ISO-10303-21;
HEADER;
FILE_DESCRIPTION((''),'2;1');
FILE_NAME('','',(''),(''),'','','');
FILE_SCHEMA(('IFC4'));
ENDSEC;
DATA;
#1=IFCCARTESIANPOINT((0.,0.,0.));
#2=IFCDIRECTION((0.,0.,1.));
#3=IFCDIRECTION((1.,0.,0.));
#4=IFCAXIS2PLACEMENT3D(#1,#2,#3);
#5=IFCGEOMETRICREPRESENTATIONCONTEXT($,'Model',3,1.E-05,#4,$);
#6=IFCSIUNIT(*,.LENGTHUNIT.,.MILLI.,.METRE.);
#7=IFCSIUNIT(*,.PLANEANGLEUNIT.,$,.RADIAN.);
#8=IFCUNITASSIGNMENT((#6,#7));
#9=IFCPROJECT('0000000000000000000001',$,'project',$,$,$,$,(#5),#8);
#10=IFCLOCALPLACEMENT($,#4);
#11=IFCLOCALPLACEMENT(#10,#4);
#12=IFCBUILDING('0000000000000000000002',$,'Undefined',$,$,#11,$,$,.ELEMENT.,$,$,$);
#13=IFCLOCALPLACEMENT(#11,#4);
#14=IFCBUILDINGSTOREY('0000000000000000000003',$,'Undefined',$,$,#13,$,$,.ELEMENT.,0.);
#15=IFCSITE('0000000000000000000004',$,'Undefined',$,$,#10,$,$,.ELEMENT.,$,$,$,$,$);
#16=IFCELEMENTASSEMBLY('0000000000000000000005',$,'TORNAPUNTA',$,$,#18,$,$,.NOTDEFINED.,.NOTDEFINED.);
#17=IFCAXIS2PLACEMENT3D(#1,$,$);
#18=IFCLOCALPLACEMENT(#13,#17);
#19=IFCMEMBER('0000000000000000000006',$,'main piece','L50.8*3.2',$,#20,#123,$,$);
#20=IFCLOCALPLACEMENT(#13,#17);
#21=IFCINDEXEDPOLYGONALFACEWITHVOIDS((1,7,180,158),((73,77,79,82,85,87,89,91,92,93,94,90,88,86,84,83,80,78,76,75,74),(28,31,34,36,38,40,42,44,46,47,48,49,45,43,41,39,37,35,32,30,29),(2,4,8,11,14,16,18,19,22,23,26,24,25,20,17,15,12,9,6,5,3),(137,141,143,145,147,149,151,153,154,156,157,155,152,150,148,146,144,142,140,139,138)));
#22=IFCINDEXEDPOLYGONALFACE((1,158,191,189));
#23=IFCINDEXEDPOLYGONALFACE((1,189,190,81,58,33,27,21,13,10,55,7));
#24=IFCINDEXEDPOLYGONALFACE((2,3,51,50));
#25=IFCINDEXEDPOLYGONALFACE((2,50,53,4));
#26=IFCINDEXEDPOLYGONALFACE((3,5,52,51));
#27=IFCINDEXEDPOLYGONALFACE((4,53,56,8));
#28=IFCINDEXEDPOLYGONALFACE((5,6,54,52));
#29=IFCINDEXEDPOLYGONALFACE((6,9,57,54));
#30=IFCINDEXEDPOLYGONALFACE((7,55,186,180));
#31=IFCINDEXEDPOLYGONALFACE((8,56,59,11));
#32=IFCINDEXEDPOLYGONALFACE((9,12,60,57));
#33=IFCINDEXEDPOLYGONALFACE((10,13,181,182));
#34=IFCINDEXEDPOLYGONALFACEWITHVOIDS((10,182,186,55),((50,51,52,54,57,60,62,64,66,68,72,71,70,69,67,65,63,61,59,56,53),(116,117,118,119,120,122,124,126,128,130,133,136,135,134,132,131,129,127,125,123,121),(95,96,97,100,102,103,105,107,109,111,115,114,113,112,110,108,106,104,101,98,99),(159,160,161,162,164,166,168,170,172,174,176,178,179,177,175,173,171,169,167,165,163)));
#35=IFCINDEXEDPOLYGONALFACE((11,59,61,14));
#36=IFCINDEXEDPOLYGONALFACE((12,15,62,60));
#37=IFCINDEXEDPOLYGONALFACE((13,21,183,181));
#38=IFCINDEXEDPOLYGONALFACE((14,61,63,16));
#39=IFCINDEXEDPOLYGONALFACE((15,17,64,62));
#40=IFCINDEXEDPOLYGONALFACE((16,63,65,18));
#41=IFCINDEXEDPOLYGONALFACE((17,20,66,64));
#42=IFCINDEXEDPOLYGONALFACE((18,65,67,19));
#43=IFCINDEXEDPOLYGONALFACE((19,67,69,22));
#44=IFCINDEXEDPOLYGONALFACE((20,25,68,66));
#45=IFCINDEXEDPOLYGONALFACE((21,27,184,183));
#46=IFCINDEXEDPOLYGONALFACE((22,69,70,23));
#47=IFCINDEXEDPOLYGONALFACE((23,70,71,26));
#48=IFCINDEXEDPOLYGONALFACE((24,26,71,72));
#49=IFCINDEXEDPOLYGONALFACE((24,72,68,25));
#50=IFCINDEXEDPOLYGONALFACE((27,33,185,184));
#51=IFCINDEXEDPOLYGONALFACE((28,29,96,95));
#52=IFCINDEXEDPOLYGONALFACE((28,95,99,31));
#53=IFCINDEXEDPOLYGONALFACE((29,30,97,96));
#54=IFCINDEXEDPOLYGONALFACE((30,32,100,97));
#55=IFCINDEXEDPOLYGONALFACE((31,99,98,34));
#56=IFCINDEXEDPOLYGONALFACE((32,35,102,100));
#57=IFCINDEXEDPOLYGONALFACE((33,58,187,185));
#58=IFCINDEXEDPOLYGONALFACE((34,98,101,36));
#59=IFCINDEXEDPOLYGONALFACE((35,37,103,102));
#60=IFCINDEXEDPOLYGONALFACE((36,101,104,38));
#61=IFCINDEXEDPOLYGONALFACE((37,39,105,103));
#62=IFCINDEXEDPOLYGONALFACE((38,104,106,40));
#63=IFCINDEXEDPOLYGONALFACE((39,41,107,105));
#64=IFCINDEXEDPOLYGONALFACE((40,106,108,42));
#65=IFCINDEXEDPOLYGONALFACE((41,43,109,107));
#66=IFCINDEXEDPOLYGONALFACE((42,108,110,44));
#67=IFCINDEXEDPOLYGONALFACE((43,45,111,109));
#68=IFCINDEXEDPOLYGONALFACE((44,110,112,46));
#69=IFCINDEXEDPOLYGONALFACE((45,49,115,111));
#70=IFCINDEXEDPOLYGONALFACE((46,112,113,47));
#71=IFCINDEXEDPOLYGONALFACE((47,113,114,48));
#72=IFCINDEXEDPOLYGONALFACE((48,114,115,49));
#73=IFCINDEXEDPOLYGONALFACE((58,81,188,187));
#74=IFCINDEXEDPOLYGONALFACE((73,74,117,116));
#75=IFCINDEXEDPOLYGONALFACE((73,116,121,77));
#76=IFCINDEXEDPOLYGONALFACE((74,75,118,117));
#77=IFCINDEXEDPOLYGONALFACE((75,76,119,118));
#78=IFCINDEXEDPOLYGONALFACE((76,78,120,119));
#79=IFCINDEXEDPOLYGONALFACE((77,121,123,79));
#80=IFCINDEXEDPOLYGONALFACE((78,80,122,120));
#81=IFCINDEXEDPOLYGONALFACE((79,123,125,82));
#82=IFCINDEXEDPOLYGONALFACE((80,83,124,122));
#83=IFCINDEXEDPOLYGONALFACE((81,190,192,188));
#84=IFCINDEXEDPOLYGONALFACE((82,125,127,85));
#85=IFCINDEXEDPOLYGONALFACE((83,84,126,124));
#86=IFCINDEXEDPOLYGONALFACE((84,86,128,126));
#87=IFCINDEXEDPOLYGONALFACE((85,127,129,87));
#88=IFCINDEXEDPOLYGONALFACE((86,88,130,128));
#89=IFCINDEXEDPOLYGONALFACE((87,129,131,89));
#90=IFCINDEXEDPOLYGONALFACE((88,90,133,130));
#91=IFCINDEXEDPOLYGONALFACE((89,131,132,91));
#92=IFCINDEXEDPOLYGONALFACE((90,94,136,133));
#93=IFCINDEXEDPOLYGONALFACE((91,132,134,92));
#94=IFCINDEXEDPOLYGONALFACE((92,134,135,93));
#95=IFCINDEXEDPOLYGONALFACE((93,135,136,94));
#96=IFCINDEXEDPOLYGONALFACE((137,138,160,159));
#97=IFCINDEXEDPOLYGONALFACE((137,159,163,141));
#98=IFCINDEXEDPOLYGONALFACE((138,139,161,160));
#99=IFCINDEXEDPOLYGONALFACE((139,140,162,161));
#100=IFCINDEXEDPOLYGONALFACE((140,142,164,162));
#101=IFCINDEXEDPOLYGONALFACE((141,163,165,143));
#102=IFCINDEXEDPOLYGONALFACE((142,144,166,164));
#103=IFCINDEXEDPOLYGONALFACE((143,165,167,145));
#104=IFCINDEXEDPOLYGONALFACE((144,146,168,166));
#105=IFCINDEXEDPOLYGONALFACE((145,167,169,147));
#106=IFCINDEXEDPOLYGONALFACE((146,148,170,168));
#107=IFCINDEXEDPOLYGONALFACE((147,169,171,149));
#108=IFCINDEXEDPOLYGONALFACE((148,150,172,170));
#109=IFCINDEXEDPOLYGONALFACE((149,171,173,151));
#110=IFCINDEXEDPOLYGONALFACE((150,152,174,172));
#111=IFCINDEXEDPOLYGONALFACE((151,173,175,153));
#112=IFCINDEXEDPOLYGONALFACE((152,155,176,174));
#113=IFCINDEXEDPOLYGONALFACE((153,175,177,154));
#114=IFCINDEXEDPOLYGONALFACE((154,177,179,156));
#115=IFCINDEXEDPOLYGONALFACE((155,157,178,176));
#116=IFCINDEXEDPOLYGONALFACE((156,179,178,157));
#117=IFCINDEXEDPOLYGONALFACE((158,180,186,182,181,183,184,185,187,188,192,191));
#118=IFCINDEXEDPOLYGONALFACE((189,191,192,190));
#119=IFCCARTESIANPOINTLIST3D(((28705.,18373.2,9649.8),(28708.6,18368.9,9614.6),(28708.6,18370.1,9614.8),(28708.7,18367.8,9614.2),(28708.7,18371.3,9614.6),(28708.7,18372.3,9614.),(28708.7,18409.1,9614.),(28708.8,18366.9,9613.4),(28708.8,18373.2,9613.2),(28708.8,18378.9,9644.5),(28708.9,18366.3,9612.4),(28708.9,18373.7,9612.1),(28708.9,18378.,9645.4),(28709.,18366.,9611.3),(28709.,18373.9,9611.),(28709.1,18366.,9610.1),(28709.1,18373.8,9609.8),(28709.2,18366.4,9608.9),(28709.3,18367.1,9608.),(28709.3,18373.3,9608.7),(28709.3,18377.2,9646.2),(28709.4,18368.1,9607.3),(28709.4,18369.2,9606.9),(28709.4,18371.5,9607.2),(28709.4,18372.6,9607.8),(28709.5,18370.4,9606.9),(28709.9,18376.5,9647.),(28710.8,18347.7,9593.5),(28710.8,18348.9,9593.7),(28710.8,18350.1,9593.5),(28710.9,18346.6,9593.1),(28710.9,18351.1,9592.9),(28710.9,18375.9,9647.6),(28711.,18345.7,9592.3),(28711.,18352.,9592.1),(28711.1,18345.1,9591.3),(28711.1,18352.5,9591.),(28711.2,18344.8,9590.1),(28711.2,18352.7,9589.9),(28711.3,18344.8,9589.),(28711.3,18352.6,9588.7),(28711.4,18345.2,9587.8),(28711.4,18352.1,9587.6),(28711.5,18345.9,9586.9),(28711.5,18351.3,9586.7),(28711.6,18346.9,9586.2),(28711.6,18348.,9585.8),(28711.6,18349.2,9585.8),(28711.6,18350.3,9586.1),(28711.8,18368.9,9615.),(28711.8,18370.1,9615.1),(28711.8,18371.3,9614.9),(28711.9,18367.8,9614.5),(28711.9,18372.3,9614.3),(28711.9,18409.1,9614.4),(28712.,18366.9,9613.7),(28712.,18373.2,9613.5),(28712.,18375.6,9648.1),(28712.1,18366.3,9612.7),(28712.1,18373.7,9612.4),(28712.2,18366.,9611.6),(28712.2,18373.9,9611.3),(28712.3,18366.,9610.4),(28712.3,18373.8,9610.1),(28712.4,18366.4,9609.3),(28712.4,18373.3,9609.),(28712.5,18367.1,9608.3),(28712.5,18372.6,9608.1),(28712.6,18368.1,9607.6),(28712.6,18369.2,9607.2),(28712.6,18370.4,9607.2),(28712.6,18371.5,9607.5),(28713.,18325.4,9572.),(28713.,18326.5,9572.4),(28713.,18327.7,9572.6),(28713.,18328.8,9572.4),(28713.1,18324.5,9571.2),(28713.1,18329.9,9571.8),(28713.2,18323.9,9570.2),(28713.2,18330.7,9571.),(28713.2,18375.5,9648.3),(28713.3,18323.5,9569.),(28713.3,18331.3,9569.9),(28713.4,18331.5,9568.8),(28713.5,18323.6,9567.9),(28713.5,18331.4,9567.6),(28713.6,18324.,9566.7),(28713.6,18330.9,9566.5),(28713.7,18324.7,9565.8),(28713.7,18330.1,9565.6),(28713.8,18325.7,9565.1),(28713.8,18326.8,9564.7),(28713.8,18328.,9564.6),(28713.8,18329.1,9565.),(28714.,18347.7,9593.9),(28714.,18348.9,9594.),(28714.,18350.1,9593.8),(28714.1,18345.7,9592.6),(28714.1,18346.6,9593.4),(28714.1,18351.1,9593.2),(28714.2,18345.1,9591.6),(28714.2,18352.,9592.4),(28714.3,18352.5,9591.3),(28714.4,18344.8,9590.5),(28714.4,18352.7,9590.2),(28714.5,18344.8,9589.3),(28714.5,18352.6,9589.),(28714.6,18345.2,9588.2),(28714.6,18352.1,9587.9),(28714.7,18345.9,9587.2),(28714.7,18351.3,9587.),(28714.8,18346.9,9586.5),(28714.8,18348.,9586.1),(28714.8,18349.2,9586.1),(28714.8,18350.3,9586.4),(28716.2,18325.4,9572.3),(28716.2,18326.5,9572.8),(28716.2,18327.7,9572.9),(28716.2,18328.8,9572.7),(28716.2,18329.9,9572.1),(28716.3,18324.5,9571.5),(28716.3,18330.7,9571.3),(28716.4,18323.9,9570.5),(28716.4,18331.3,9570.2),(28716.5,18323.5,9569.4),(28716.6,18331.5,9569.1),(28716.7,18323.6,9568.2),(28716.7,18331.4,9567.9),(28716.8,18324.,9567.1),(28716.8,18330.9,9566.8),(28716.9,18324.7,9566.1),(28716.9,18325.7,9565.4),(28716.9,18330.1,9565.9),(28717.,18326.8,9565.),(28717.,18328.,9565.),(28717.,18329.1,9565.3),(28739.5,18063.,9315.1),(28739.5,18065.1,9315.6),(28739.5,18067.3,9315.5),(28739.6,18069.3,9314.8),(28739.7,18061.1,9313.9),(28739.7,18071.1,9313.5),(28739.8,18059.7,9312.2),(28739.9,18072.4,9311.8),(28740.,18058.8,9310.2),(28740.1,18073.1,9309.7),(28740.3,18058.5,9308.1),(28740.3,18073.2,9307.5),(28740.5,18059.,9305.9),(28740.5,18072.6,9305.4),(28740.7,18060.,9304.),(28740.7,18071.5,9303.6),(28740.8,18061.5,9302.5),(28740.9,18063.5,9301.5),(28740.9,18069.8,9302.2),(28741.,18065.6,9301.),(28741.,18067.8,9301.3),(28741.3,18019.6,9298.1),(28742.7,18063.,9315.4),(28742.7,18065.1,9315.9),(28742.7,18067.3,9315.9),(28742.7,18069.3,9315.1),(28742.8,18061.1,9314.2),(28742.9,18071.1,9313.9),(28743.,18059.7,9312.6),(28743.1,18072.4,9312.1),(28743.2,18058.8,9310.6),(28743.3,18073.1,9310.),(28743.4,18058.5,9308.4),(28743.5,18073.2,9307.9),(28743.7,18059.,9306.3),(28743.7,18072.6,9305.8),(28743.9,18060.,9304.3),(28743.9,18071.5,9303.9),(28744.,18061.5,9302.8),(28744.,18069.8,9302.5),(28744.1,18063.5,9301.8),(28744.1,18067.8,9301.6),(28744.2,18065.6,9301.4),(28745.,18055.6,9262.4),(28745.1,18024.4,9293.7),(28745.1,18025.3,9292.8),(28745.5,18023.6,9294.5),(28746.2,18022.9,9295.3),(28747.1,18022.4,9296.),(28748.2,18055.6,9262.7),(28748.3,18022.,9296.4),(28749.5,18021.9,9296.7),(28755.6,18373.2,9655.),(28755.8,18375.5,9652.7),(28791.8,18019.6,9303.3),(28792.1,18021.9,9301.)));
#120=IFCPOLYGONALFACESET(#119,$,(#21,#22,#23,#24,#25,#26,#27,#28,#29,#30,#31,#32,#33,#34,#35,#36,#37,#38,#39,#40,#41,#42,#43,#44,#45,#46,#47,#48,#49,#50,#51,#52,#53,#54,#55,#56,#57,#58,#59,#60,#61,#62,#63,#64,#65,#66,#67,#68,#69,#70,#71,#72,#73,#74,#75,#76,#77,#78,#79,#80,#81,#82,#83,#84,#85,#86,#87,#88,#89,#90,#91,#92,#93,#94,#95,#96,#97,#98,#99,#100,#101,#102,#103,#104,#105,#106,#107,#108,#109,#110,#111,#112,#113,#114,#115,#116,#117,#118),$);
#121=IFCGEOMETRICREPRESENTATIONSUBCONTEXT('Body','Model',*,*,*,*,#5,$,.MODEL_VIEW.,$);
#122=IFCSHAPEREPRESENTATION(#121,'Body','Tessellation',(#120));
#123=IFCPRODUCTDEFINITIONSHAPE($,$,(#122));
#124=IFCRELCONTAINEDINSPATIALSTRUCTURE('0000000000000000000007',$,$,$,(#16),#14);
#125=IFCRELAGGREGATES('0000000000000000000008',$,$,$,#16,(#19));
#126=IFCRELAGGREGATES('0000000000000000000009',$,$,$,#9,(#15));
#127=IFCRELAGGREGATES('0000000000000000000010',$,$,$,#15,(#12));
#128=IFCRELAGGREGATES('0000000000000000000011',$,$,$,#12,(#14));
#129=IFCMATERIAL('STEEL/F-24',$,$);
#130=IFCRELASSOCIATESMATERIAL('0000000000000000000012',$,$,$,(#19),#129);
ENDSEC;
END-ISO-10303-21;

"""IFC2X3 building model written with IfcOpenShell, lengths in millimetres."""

from ifc_helpers import new_model, si_unit, frame, origin_with_axes, origin_2d_with_axis, place, context, subcontext, project, spatial, circle, l_section, extrude, source, transform, mapped, material, element, aggregate, save


model = new_model("IFC2X3")

# Units and contexts
model_context = context("Model", 3, precision=1e-05, world=origin_with_axes())
body_context = subcontext(model_context, "Body", "Model", "MODEL_VIEW")
ifc_project = project(units=[si_unit("LENGTHUNIT", "METRE", prefix="MILLI"), si_unit("PLANEANGLEUNIT", "RADIAN")], contexts=[model_context])

# Site, building, storey
site_placement = place(None, origin_with_axes())
site = spatial("IfcSite", under=ifc_project, at=site_placement, Name="Undefined", CompositionType="ELEMENT")
building_placement = place(site_placement, origin_with_axes())
building = spatial("IfcBuilding", under=site, at=building_placement, Name="Undefined", CompositionType="ELEMENT")
storey_placement = place(building_placement, origin_with_axes())
storey = spatial("IfcBuildingStorey", under=building, at=storey_placement, Name="Undefined", CompositionType="ELEMENT", Elevation=0.0)

# Element assembly, member, openings
ifc_material_1 = material(Name="STEEL/F-24")
shared_shape_1 = source(origin_with_axes(), body_context, "Body", "SweptSolid", [
    extrude(circle(Radius=4.0, at=origin_2d_with_axis()), frame((0.0, -3.3, 0.0), z_axis=(0.0, 1.0, 0.0), x_axis=(1.0, 0.0, 0.0)), (0.0, 0.0, 1.0), 3.4),
])
shared_shape_2 = source(origin_with_axes(), body_context, "Body", "SweptSolid", [
    extrude(circle(Radius=7.3, at=origin_2d_with_axis()), frame((0.0, -3.3, 0.0), z_axis=(0.0, 1.0, 0.0), x_axis=(1.0, 0.0, 0.0)), (0.0, 0.0, 1.0), 3.4),
])
assembly_1_placement = place(storey_placement, origin_with_axes())
assembly_1 = element("IfcElementAssembly", 1, at=assembly_1_placement, inside=storey, Name="TORNAPUNTA", AssemblyPlace="NOTDEFINED", PredefinedType="NOTDEFINED")
member_1_placement = place(assembly_1_placement, frame((28768.4, 18037.6, 9282.8), z_axis=(0.994727, 0.0, 0.102562), x_axis=(-0.072522, 0.707107, 0.703378)))
member_1 = element("IfcMember", 2, at=member_1_placement, material=ifc_material_1, Name="main piece", Description="L50.8*3.2", context=body_context, shape_type="SweptSolid", body=[
    extrude(l_section(Depth=50.8, Width=50.8, Thickness=3.2, FilletRadius=4.8, at=origin_2d_with_axis()), frame((500.0, 0.0, 0.0), z_axis=(-1.0, 0.0, 0.0), x_axis=(0.0, -1.0, 0.0)), (0.0, 0.0, 1.0), 500.0),
])
opening_1_placement = place(assembly_1_placement, frame((28709.0, 18369.9, 9610.8), z_axis=(0.072522, 0.707107, -0.703378), x_axis=(0.072522, -0.707107, -0.703378)))
element("IfcOpeningElement", 3, at=opening_1_placement, cuts=member_1, ObjectType="Opening", context=body_context, shape_type="MappedRepresentation", body=[
    mapped(shared_shape_1, transform((0.0, 0.0, 0.0))),
    mapped(shared_shape_1, transform((30.0, 0.0, 0.0))),
    mapped(shared_shape_1, transform((60.0, 0.0, 0.0))),
])
opening_2_placement = place(assembly_1_placement, frame((28740.2, 18065.9, 9308.4), z_axis=(-0.072522, -0.707107, 0.703378), x_axis=(-0.072522, 0.707107, 0.703378)))
element("IfcOpeningElement", 4, at=opening_2_placement, cuts=member_1, ObjectType="Opening", context=body_context, shape_type="MappedRepresentation", body=[
    mapped(shared_shape_2, transform((0.0, 0.0, 0.0))),
])
aggregate(assembly_1, [member_1])

save(model, "model.ifc")
